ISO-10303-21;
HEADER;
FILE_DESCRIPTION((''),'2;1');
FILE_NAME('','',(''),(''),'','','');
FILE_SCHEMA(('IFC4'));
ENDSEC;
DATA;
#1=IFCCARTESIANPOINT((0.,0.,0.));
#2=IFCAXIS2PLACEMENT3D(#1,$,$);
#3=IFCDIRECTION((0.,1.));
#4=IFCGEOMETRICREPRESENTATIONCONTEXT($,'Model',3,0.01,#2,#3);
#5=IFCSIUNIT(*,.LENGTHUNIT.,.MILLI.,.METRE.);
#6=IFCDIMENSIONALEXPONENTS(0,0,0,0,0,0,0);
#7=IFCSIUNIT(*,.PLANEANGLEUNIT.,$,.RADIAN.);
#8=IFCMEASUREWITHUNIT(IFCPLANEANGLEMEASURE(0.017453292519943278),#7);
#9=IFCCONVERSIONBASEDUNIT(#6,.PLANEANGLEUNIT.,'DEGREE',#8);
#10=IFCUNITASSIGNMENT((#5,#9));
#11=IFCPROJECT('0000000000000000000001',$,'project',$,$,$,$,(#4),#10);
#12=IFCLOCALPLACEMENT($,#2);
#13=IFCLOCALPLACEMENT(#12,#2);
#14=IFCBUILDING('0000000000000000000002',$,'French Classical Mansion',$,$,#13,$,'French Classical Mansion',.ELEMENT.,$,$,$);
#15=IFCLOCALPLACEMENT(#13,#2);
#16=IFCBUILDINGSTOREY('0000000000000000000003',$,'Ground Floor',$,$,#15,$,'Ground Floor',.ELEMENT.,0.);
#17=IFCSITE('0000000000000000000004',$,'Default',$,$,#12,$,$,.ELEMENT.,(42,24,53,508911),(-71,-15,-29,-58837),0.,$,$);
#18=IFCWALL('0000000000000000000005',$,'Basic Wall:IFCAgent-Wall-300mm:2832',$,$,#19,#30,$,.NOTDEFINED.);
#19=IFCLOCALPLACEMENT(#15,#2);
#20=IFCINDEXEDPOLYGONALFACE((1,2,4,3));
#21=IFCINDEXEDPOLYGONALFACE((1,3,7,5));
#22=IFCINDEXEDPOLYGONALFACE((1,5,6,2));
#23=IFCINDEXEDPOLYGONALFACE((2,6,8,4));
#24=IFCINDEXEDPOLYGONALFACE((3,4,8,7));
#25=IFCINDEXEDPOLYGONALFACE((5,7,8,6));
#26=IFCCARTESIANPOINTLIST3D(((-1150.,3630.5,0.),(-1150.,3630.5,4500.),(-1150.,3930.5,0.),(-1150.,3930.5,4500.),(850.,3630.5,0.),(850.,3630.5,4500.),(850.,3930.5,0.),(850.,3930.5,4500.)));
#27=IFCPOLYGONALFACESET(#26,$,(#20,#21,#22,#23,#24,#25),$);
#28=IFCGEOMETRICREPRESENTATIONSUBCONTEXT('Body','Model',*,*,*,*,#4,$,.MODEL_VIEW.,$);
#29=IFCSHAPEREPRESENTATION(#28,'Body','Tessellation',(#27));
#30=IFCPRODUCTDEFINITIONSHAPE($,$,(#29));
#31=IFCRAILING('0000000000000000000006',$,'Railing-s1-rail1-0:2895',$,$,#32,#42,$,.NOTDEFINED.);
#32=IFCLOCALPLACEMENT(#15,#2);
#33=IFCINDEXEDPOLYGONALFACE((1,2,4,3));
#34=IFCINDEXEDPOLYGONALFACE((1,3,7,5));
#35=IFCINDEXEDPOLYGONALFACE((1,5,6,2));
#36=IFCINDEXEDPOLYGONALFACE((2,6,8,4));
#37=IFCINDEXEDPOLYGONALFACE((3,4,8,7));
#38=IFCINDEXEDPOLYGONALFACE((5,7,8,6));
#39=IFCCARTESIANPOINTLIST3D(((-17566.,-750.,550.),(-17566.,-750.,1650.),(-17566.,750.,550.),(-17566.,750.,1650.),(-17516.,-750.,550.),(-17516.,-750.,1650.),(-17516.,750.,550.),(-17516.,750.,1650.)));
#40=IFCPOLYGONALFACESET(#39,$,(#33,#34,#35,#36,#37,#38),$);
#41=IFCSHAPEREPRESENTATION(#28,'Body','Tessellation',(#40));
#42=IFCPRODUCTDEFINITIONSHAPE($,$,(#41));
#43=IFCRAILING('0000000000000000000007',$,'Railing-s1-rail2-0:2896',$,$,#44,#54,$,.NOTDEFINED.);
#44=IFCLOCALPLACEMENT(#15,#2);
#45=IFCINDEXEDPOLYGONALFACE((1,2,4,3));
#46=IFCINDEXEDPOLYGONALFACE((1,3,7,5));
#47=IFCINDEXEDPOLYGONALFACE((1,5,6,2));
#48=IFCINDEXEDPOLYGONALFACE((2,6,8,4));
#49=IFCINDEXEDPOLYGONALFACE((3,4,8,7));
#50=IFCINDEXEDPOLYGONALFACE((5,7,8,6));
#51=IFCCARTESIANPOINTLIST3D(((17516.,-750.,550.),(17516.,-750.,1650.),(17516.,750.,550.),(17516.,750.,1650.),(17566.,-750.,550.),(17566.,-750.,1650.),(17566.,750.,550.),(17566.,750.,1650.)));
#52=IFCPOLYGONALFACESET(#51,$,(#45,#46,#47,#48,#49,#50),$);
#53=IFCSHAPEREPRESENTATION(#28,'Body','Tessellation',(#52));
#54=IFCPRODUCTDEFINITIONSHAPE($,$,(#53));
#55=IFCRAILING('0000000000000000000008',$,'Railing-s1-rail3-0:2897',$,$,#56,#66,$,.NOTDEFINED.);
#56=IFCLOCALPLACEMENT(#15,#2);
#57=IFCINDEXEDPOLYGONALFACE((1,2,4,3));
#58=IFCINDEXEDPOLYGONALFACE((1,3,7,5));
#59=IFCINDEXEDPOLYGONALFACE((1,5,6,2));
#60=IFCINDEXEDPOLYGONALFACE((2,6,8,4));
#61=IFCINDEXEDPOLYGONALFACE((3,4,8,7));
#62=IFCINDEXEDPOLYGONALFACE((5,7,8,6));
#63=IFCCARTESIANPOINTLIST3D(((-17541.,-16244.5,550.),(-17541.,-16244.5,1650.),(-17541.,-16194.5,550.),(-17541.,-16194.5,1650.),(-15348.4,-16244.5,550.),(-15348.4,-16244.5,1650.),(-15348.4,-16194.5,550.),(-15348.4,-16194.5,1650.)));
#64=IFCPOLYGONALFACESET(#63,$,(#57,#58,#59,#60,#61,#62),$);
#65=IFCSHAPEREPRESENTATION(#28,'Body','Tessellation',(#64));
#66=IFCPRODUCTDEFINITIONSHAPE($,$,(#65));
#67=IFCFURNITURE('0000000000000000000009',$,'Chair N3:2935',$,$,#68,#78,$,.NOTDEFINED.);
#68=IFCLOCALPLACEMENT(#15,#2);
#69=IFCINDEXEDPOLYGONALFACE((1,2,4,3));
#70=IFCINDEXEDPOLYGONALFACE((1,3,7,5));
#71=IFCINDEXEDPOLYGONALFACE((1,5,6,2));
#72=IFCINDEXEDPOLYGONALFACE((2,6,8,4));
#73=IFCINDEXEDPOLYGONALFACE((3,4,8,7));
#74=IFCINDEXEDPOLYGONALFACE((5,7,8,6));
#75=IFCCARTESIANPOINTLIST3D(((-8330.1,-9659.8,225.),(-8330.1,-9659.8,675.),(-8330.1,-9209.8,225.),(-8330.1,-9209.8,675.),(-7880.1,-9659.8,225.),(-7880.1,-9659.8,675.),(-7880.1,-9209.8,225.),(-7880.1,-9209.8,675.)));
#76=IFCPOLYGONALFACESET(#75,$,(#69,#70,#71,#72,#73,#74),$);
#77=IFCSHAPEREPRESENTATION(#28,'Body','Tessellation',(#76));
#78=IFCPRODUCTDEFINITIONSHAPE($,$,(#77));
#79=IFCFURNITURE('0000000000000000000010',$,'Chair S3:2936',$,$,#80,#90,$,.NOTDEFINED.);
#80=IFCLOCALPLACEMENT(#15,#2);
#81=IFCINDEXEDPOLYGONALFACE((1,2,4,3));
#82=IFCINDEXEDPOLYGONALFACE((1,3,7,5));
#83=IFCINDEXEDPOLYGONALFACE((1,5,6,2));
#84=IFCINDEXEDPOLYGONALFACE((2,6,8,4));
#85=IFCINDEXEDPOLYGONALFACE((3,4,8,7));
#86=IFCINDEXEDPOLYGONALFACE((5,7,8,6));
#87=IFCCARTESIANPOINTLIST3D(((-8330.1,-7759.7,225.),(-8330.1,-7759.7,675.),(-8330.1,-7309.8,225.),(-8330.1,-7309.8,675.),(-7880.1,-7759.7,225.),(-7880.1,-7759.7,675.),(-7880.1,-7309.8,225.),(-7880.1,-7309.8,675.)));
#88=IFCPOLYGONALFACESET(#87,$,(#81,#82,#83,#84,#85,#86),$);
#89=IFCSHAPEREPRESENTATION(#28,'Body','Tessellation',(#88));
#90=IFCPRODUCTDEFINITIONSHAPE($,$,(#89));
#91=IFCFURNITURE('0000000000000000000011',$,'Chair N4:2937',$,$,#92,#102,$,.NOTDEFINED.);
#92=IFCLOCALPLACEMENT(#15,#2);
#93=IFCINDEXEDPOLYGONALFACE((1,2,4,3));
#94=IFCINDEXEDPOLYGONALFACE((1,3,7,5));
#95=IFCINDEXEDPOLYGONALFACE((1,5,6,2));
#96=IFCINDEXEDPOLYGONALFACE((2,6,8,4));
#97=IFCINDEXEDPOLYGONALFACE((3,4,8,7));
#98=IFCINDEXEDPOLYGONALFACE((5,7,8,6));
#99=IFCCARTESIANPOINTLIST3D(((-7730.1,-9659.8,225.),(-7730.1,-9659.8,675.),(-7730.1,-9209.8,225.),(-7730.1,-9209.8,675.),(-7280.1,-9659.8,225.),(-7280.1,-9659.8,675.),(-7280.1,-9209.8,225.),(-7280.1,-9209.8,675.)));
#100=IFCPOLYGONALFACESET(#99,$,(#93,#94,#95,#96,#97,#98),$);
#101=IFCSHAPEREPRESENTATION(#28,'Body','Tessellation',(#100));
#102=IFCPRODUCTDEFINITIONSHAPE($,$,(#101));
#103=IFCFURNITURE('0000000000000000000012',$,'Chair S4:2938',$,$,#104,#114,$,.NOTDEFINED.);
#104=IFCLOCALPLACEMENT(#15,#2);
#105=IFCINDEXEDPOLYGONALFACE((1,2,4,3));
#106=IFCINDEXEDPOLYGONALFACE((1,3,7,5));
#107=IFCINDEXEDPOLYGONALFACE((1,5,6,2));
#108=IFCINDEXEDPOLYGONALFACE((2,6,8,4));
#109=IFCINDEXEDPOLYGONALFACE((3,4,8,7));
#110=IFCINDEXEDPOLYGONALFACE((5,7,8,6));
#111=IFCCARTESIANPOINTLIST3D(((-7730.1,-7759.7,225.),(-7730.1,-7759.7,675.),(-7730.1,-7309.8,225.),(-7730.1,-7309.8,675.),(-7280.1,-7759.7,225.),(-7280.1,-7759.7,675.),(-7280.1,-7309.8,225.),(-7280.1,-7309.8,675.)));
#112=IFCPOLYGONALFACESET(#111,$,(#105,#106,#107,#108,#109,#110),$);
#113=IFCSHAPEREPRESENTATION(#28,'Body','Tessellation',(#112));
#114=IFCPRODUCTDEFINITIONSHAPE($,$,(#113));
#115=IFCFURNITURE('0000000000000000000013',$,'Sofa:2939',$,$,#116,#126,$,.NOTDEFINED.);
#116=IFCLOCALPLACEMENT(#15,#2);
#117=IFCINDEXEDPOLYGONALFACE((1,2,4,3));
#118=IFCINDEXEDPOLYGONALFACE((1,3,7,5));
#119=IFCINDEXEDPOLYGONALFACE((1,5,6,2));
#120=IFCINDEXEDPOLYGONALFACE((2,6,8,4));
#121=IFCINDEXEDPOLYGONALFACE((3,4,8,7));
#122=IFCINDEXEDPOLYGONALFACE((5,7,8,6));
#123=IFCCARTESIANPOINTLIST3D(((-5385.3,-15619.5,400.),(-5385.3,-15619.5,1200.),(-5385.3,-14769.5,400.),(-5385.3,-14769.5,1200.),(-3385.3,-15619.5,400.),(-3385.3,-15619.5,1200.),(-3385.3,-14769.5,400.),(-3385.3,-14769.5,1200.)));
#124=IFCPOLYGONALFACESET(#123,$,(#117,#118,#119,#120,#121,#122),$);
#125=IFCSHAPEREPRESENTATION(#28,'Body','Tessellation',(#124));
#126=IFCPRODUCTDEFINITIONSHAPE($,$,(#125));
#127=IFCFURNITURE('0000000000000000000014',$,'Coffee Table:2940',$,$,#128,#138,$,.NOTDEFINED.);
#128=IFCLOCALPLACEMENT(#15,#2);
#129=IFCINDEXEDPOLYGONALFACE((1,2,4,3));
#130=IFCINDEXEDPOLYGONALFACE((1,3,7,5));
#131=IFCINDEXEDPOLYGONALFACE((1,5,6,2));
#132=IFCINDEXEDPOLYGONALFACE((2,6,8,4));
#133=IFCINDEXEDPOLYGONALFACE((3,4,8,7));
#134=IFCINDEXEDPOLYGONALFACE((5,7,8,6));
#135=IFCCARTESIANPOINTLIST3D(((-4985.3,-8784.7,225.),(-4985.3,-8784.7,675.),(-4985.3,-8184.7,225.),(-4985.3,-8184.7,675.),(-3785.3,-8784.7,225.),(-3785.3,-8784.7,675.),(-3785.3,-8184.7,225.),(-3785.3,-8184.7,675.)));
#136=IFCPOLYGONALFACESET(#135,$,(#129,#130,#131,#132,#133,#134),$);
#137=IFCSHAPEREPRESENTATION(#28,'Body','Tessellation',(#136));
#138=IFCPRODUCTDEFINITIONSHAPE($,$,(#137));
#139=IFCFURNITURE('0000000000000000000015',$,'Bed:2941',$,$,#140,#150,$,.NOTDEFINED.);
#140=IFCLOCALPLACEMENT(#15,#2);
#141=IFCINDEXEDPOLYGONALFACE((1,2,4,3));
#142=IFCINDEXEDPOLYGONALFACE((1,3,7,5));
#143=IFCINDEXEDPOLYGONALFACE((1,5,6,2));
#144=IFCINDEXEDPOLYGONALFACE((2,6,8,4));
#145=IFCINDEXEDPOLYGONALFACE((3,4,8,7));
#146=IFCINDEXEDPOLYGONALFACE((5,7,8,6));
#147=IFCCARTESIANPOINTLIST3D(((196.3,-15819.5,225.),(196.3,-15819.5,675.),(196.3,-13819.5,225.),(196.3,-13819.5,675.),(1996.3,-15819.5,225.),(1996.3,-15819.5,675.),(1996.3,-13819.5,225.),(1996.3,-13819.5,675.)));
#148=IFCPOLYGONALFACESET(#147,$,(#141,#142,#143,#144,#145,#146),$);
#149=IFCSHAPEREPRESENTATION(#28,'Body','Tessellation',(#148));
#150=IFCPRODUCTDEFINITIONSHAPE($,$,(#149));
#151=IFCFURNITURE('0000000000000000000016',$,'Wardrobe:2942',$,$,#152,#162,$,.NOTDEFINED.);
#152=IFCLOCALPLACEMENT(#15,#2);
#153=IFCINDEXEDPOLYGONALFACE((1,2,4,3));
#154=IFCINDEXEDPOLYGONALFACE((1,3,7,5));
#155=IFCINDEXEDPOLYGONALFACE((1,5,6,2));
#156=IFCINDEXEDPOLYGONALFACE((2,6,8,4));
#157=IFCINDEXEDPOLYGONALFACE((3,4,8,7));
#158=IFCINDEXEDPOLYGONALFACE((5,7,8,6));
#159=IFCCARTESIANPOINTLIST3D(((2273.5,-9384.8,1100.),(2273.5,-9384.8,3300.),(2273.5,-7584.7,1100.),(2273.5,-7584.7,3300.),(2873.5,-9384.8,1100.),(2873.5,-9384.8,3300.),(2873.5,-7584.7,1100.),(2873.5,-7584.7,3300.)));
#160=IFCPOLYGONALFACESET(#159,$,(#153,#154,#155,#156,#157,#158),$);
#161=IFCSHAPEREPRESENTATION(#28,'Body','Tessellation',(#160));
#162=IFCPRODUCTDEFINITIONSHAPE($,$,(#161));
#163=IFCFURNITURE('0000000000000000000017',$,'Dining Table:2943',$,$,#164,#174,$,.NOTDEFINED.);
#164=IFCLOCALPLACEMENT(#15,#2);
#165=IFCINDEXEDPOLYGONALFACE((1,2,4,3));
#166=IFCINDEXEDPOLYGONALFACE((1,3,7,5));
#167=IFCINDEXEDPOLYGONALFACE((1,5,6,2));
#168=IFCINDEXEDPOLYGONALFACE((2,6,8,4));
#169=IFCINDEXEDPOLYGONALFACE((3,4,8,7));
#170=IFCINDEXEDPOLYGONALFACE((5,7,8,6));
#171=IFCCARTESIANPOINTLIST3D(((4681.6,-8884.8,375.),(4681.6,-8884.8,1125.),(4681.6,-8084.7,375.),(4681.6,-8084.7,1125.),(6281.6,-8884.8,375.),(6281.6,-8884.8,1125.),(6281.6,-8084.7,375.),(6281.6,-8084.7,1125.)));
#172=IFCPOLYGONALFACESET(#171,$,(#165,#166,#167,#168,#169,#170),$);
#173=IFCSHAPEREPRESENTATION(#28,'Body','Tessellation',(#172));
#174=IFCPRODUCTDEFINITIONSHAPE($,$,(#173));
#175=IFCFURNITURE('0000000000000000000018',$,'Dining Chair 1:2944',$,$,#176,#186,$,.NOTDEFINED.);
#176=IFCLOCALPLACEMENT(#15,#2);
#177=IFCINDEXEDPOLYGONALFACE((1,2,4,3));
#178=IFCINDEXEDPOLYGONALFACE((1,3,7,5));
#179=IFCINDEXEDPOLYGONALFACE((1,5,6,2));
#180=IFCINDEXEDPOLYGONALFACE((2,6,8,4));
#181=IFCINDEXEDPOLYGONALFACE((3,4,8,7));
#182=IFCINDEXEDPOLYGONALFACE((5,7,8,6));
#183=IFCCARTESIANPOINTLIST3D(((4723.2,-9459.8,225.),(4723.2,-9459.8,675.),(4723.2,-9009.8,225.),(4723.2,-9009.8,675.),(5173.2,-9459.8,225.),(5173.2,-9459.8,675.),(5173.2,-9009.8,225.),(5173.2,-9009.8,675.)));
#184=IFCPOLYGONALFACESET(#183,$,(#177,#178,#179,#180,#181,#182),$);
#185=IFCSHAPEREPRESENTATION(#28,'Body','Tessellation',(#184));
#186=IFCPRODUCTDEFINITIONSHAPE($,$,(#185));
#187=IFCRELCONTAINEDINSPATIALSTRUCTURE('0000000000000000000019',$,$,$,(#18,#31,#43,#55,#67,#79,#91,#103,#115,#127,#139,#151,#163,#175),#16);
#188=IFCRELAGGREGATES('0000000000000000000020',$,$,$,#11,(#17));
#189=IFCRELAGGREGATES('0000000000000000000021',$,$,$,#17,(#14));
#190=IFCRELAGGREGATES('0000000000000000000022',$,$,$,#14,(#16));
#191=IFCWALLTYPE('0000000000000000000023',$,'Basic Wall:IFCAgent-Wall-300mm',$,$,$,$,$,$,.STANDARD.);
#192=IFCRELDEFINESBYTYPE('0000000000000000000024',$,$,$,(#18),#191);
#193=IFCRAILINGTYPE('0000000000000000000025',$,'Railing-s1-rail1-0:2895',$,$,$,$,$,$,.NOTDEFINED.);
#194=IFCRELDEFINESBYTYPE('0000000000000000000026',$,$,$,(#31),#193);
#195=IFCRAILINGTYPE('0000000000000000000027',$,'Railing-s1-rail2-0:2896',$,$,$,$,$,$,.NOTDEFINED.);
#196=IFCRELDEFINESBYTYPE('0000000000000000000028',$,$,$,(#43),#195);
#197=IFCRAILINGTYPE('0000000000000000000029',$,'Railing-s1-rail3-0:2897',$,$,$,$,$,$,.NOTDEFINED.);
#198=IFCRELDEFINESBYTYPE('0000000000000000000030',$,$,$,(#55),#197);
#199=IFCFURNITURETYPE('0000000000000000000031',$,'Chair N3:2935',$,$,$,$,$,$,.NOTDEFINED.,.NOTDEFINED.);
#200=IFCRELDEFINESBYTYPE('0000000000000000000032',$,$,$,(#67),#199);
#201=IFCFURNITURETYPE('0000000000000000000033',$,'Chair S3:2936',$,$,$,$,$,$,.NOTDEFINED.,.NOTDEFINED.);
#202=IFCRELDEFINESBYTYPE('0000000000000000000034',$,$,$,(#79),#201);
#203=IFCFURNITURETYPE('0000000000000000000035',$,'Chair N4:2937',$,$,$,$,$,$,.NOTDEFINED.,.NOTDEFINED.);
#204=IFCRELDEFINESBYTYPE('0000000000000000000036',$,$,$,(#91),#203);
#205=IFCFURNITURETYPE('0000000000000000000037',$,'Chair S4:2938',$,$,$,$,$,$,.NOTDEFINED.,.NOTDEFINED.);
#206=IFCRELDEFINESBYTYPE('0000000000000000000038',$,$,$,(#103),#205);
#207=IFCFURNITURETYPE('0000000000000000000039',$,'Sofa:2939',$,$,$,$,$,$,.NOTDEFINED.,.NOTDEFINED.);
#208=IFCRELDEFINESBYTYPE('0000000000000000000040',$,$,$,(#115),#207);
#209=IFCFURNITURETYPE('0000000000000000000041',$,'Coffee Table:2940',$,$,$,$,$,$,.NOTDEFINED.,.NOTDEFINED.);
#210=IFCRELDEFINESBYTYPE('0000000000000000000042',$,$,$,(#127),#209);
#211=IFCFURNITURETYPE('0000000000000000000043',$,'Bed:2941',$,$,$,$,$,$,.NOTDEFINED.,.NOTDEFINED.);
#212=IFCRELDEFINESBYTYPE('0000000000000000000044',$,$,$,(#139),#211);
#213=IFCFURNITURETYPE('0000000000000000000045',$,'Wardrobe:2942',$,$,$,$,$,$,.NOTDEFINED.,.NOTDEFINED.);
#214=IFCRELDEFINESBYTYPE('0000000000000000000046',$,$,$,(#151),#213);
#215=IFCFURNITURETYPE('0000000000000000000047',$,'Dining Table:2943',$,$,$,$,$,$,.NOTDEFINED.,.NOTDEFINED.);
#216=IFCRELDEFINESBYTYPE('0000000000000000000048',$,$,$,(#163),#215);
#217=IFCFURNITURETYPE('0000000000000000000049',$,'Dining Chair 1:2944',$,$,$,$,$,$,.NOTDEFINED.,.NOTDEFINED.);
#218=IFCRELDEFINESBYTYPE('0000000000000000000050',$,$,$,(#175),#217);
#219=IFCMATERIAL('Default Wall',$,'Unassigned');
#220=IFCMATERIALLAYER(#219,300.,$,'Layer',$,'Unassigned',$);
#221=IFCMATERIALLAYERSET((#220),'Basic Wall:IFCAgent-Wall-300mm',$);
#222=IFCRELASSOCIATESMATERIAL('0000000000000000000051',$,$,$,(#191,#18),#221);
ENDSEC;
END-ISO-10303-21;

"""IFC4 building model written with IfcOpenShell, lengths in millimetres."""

from ifc_helpers import new_model, entity, si_unit, converted_unit, direction, frame, frame_2d, origin, origin_2d_with_axis, place, context, subcontext, project, spatial, rectangle, extrude, material, layer, layer_set, layer_usage, type_object, element, save


model = new_model("IFC4")

# Units and contexts
model_context = context("Model", 3, precision=0.01, world=origin(), true_north=direction((0.0, 1.0)))
body_context = subcontext(model_context, "Body", "Model", "MODEL_VIEW")
ifc_project = project(units=[si_unit("LENGTHUNIT", "METRE", prefix="MILLI"), converted_unit("PLANEANGLEUNIT", "DEGREE", entity("IfcPlaneAngleMeasure", 0.017453292519943278), si_unit("PLANEANGLEUNIT", "RADIAN"), dimensions=[0, 0, 0, 0, 0, 0, 0])], contexts=[model_context])

# Site, building, storey
site_placement = place(None, origin())
site = spatial("IfcSite", under=ifc_project, at=site_placement, Name="Default", CompositionType="ELEMENT", RefLatitude=(42, 24, 53, 508911), RefLongitude=(-71, -15, -29, -58837), RefElevation=0.0)
building_placement = place(site_placement, origin())
building = spatial("IfcBuilding", under=site, at=building_placement, Name="French Classical Mansion", LongName="French Classical Mansion", CompositionType="ELEMENT")
storey_placement = place(building_placement, origin())
storey = spatial("IfcBuildingStorey", under=building, at=storey_placement, Name="Ground Floor", LongName="Ground Floor", CompositionType="ELEMENT", Elevation=0.0)

# Wall
ifc_material = material(Name="Default Wall", Category="Unassigned")
ifc_layer = layer(ifc_material, 300.0, Name="Layer", Category="Unassigned")
ifc_layer_set = layer_set([ifc_layer], Name="Basic Wall:IFCAgent-Wall-300mm")
ifc_layer_usage = layer_usage(ifc_layer_set, "AXIS2", "NEGATIVE", 150.0)
wall_type = type_object("IfcWallType", Name="Basic Wall:IFCAgent-Wall-300mm", PredefinedType="STANDARD", material=ifc_layer_set)
wall_placement = place(storey_placement, frame((850.0, 3780.5, 0.0), z_axis=(0.0, 0.0, 1.0), x_axis=(-1.0, 0.0, 0.0)))
element("IfcWall", 1, at=wall_placement, inside=storey, type_object=wall_type, material=ifc_layer_usage, Name="Basic Wall:IFCAgent-Wall-300mm:2832", PredefinedType="NOTDEFINED", context=body_context, shape_type="SweptSolid", body=[
    extrude(rectangle(XDim=2000.0, YDim=300.0, at=frame_2d((1000.0, 0.0), x_axis=(-1.0, 0.0))), origin(), (0.0, 0.0, 1.0), 4500.0),
])

# Railings
railing_type_1 = type_object("IfcRailingType", Name="Railing-s1-rail1-0:2895", PredefinedType="NOTDEFINED")
railing_1_placement = place(storey_placement, origin())
element("IfcRailing", 2, at=railing_1_placement, inside=storey, type_object=railing_type_1, Name="Railing-s1-rail1-0:2895", PredefinedType="NOTDEFINED", context=body_context, shape_type="SweptSolid", body=[
    extrude(rectangle(XDim=1500.0, YDim=50.0, at=origin_2d_with_axis()), frame((-17541.0, 0.0, 550.0), z_axis=(0.0, 0.0, 1.0), x_axis=(0.0, 1.0, 0.0)), (0.0, 0.0, 1.0), 1100.0),
])
railing_type_2 = type_object("IfcRailingType", Name="Railing-s1-rail2-0:2896", PredefinedType="NOTDEFINED")
railing_2_placement = place(storey_placement, origin())
element("IfcRailing", 3, at=railing_2_placement, inside=storey, type_object=railing_type_2, Name="Railing-s1-rail2-0:2896", PredefinedType="NOTDEFINED", context=body_context, shape_type="SweptSolid", body=[
    extrude(rectangle(XDim=1500.0, YDim=50.0, at=frame_2d((0.0, 0.0), x_axis=(1.0, 0.0))), frame((17541.0, 0.0, 550.0), z_axis=(0.0, 0.0, 1.0), x_axis=(0.0, 1.0, 0.0)), (0.0, 0.0, 1.0), 1100.0),
])
railing_type_3 = type_object("IfcRailingType", Name="Railing-s1-rail3-0:2897", PredefinedType="NOTDEFINED")
railing_3_placement = place(storey_placement, origin())
element("IfcRailing", 4, at=railing_3_placement, inside=storey, type_object=railing_type_3, Name="Railing-s1-rail3-0:2897", PredefinedType="NOTDEFINED", context=body_context, shape_type="SweptSolid", body=[
    extrude(rectangle(XDim=2192.6, YDim=50.0, at=frame_2d((0.0, 0.0), x_axis=(1.0, 0.0))), frame((-16444.7, -16219.5, 550.0)), (0.0, 0.0, 1.0), 1100.0),
])

# Furniture
furniture_type_1 = type_object("IfcFurnitureType", Name="Chair N3:2935", PredefinedType="NOTDEFINED")
furniture_1_placement = place(storey_placement, origin())
element("IfcFurniture", 5, at=furniture_1_placement, inside=storey, type_object=furniture_type_1, Name="Chair N3:2935", PredefinedType="NOTDEFINED", context=body_context, shape_type="SweptSolid", body=[
    extrude(rectangle(XDim=450.0, YDim=450.0, at=frame_2d((0.0, 0.0), x_axis=(1.0, 0.0))), frame((-8105.1, -9434.8, 225.0)), (0.0, 0.0, 1.0), 450.0),
])
furniture_type_2 = type_object("IfcFurnitureType", Name="Chair S3:2936", PredefinedType="NOTDEFINED")
furniture_2_placement = place(storey_placement, origin())
element("IfcFurniture", 6, at=furniture_2_placement, inside=storey, type_object=furniture_type_2, Name="Chair S3:2936", PredefinedType="NOTDEFINED", context=body_context, shape_type="SweptSolid", body=[
    extrude(rectangle(XDim=450.0, YDim=450.0, at=origin_2d_with_axis()), frame((-8105.1, -7534.8, 225.0)), (0.0, 0.0, 1.0), 450.0),
])
furniture_type_3 = type_object("IfcFurnitureType", Name="Chair N4:2937", PredefinedType="NOTDEFINED")
furniture_3_placement = place(storey_placement, origin())
element("IfcFurniture", 7, at=furniture_3_placement, inside=storey, type_object=furniture_type_3, Name="Chair N4:2937", PredefinedType="NOTDEFINED", context=body_context, shape_type="SweptSolid", body=[
    extrude(rectangle(XDim=450.0, YDim=450.0, at=frame_2d((0.0, 0.0), x_axis=(1.0, 0.0))), frame((-7505.1, -9434.8, 225.0)), (0.0, 0.0, 1.0), 450.0),
])
furniture_type_4 = type_object("IfcFurnitureType", Name="Chair S4:2938", PredefinedType="NOTDEFINED")
furniture_4_placement = place(storey_placement, origin())
element("IfcFurniture", 8, at=furniture_4_placement, inside=storey, type_object=furniture_type_4, Name="Chair S4:2938", PredefinedType="NOTDEFINED", context=body_context, shape_type="SweptSolid", body=[
    extrude(rectangle(XDim=450.0, YDim=450.0, at=origin_2d_with_axis()), frame((-7505.1, -7534.8, 225.0)), (0.0, 0.0, 1.0), 450.0),
])
furniture_type_5 = type_object("IfcFurnitureType", Name="Sofa:2939", PredefinedType="NOTDEFINED")
furniture_5_placement = place(storey_placement, origin())
element("IfcFurniture", 9, at=furniture_5_placement, inside=storey, type_object=furniture_type_5, Name="Sofa:2939", PredefinedType="NOTDEFINED", context=body_context, shape_type="SweptSolid", body=[
    extrude(rectangle(XDim=2000.0, YDim=850.0, at=frame_2d((0.0, 0.0), x_axis=(1.0, 0.0))), frame((-4385.3, -15194.5, 400.0)), (0.0, 0.0, 1.0), 800.0),
])
furniture_type_6 = type_object("IfcFurnitureType", Name="Coffee Table:2940", PredefinedType="NOTDEFINED")
furniture_6_placement = place(storey_placement, origin())
element("IfcFurniture", 10, at=furniture_6_placement, inside=storey, type_object=furniture_type_6, Name="Coffee Table:2940", PredefinedType="NOTDEFINED", context=body_context, shape_type="SweptSolid", body=[
    extrude(rectangle(XDim=1200.0, YDim=600.0, at=frame_2d((0.0, 0.0), x_axis=(1.0, 0.0))), frame((-4385.3, -8484.7, 225.0)), (0.0, 0.0, 1.0), 450.0),
])
furniture_type_7 = type_object("IfcFurnitureType", Name="Bed:2941", PredefinedType="NOTDEFINED")
furniture_7_placement = place(storey_placement, origin())
element("IfcFurniture", 11, at=furniture_7_placement, inside=storey, type_object=furniture_type_7, Name="Bed:2941", PredefinedType="NOTDEFINED", context=body_context, shape_type="SweptSolid", body=[
    extrude(rectangle(XDim=1800.0, YDim=2000.0, at=origin_2d_with_axis()), frame((1096.3, -14819.5, 225.0)), (0.0, 0.0, 1.0), 450.0),
])
furniture_type_8 = type_object("IfcFurnitureType", Name="Wardrobe:2942", PredefinedType="NOTDEFINED")
furniture_8_placement = place(storey_placement, origin())
element("IfcFurniture", 12, at=furniture_8_placement, inside=storey, type_object=furniture_type_8, Name="Wardrobe:2942", PredefinedType="NOTDEFINED", context=body_context, shape_type="SweptSolid", body=[
    extrude(rectangle(XDim=600.0, YDim=1800.0, at=origin_2d_with_axis()), frame((2573.5, -8484.8, 1100.0)), (0.0, 0.0, 1.0), 2200.0),
])
furniture_type_9 = type_object("IfcFurnitureType", Name="Dining Table:2943", PredefinedType="NOTDEFINED")
furniture_9_placement = place(storey_placement, origin())
element("IfcFurniture", 13, at=furniture_9_placement, inside=storey, type_object=furniture_type_9, Name="Dining Table:2943", PredefinedType="NOTDEFINED", context=body_context, shape_type="SweptSolid", body=[
    extrude(rectangle(XDim=1600.0, YDim=800.0, at=origin_2d_with_axis()), frame((5481.6, -8484.8, 375.0)), (0.0, 0.0, 1.0), 750.0),
])
furniture_type_10 = type_object("IfcFurnitureType", Name="Dining Chair 1:2944", PredefinedType="NOTDEFINED")
furniture_10_placement = place(storey_placement, origin())
element("IfcFurniture", 14, at=furniture_10_placement, inside=storey, type_object=furniture_type_10, Name="Dining Chair 1:2944", PredefinedType="NOTDEFINED", context=body_context, shape_type="SweptSolid", body=[
    extrude(rectangle(XDim=450.0, YDim=450.0, at=origin_2d_with_axis()), frame((4948.2, -9234.8, 225.0)), (0.0, 0.0, 1.0), 450.0),
])

save(model, "model.ifc")
